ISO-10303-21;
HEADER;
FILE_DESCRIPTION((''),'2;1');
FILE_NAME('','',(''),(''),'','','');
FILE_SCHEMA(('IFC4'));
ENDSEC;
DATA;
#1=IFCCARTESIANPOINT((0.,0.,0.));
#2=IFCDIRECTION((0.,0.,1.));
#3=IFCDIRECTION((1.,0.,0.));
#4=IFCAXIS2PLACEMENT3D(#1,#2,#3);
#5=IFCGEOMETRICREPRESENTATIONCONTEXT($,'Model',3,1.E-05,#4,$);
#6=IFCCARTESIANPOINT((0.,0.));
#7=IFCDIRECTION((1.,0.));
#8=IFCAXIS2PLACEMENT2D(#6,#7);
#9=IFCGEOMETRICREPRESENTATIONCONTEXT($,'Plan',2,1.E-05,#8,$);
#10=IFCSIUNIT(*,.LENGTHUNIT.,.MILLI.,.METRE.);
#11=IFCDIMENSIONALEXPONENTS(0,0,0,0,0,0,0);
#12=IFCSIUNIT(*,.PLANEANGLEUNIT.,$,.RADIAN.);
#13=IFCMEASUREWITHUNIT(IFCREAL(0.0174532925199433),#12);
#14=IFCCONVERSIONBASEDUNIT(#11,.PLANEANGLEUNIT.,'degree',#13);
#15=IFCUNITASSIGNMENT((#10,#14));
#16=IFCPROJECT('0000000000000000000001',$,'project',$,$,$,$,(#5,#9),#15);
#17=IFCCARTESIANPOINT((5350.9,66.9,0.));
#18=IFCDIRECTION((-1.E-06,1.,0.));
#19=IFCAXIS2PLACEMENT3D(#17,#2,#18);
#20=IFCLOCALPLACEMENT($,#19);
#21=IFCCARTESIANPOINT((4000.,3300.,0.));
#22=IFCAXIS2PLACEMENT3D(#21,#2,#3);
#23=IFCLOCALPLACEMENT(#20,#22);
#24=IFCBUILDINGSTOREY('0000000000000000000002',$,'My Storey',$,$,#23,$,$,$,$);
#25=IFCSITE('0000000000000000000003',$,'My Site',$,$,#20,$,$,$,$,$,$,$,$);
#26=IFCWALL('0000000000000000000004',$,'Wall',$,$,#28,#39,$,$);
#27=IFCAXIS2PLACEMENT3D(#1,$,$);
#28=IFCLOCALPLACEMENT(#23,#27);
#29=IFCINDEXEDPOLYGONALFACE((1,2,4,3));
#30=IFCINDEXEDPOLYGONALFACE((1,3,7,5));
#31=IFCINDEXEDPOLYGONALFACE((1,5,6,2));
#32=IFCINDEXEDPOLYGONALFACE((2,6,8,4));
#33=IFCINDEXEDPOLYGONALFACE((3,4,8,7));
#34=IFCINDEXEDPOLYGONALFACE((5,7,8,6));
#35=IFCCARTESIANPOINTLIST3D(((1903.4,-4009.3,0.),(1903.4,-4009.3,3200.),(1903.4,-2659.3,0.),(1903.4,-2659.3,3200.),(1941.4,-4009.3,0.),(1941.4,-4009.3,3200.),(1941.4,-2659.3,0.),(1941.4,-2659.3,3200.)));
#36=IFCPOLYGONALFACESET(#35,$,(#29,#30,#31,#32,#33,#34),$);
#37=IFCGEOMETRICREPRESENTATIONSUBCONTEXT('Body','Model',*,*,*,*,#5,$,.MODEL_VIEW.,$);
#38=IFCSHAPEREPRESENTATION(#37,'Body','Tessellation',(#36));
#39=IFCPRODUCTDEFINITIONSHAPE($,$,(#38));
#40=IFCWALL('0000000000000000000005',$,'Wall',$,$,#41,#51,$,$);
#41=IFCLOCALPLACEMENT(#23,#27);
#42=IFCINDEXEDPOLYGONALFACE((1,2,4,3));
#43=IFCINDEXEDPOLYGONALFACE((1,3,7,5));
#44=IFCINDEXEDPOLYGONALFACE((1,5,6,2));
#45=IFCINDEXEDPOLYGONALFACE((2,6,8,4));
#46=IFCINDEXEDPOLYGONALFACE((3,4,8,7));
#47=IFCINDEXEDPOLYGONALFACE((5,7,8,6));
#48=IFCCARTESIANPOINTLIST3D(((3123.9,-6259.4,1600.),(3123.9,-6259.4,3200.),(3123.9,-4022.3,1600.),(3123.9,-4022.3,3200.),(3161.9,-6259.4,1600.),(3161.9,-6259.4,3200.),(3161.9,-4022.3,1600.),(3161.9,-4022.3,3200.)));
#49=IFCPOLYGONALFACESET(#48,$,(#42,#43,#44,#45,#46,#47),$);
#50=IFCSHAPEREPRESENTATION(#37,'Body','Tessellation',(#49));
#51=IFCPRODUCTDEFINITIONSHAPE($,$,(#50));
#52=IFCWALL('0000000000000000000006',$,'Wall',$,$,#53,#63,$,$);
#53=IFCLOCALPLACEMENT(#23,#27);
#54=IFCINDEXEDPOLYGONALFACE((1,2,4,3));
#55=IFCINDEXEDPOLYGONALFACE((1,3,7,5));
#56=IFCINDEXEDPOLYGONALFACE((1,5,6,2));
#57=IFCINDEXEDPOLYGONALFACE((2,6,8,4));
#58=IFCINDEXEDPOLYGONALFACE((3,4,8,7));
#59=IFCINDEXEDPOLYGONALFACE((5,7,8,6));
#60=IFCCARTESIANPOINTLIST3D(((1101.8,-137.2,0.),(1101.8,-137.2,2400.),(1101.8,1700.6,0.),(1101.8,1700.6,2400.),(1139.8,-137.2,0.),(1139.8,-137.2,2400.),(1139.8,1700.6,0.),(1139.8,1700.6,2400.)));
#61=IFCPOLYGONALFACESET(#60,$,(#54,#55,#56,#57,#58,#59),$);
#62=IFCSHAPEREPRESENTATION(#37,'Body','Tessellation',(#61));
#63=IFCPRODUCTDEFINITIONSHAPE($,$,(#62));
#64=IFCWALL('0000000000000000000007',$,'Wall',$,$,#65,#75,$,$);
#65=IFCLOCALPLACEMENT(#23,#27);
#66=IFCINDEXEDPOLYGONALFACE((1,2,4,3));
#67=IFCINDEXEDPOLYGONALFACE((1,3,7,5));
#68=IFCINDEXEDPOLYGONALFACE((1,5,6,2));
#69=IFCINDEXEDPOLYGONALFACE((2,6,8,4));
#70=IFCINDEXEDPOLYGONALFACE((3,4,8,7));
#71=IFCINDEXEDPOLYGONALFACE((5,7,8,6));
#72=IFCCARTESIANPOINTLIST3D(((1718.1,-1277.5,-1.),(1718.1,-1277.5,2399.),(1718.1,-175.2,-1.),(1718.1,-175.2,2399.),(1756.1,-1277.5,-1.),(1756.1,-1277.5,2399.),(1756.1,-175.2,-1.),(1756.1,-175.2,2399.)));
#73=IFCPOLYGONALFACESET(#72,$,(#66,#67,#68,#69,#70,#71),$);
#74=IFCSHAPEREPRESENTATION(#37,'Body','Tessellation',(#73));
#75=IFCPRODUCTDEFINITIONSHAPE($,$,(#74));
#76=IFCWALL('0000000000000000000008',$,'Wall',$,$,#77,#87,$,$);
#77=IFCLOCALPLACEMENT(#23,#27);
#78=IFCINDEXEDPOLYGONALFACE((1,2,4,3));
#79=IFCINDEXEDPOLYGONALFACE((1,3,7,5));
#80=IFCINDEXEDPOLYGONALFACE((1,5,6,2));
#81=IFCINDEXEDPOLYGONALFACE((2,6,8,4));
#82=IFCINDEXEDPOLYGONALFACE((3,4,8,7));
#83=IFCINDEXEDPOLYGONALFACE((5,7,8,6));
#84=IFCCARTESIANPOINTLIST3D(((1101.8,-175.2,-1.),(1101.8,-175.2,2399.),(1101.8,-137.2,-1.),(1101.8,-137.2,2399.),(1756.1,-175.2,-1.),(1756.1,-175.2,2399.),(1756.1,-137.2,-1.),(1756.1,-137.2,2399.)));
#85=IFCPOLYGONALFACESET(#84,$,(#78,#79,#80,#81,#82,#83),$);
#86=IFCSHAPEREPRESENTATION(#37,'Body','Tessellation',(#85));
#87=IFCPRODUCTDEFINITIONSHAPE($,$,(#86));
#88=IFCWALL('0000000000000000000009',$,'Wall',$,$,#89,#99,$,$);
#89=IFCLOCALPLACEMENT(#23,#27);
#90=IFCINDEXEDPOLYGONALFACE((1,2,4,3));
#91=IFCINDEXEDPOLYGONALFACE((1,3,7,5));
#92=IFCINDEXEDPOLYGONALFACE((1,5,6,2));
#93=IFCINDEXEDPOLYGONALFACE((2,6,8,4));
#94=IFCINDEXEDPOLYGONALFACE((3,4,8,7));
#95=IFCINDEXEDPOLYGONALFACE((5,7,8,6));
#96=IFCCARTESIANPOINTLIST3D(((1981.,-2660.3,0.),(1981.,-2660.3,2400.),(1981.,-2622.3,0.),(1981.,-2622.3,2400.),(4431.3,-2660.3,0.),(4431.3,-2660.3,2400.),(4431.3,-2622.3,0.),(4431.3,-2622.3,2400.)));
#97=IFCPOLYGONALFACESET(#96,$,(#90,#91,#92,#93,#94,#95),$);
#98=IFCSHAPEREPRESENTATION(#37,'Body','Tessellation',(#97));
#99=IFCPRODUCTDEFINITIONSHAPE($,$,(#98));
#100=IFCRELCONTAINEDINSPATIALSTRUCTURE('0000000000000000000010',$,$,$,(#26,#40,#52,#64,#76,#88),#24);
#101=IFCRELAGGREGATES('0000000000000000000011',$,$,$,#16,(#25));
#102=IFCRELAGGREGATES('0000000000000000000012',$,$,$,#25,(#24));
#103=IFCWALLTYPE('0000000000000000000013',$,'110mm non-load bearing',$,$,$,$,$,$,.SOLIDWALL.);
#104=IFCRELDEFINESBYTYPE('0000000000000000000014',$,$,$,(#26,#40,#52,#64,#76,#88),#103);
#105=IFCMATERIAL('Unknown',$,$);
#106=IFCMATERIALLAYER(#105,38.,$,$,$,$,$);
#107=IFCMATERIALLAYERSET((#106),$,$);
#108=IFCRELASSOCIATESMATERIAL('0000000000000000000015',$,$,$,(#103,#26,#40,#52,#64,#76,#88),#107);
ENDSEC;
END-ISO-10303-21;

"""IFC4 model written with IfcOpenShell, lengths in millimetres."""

from ifc_helpers import new_model, entity, si_unit, converted_unit, frame, origin_with_axes, origin_2d_with_axis, place, context, subcontext, project, spatial, indexed_curve, outline, extrude, material, layer, layer_set, layer_usage, type_object, element, save


model = new_model("IFC4")

# Units and contexts
model_context = context("Model", 3, precision=1e-05, world=origin_with_axes())
plan_context = context("Plan", 2, precision=1e-05, world=origin_2d_with_axis())
body_context = subcontext(model_context, "Body", "Model", "MODEL_VIEW")
ifc_project = project(units=[si_unit("LENGTHUNIT", "METRE", prefix="MILLI"), converted_unit("PLANEANGLEUNIT", "degree", entity("IfcReal", 0.0174532925199433), si_unit("PLANEANGLEUNIT", "RADIAN"), dimensions=[0, 0, 0, 0, 0, 0, 0])], contexts=[model_context, plan_context])

# Site, storey
site_placement = place(None, frame((5350.9, 66.9, 0.0), z_axis=(0.0, 0.0, 1.0), x_axis=(-0.000001, 1.0, 0.0)))
site = spatial("IfcSite", under=ifc_project, at=site_placement, Name="My Site")
storey_placement = place(site_placement, frame((4000.0, 3300.0, 0.0), z_axis=(0.0, 0.0, 1.0), x_axis=(1.0, 0.0, 0.0)))
storey = spatial("IfcBuildingStorey", under=site, at=storey_placement, Name="My Storey")

# Shared definitions
ifc_material = material(Name="Unknown")

# Walls
ifc_layer_1 = layer(ifc_material, 38.0)
ifc_layer_set_1 = layer_set([ifc_layer_1])
wall_type_1 = type_object("IfcWallType", Name="110mm non-load bearing", PredefinedType="SOLIDWALL", material=ifc_layer_set_1)
ifc_layer_usage_1 = layer_usage(ifc_layer_set_1, "AXIS2", "POSITIVE", 0.0)
wall_1_placement = place(storey_placement, frame((1903.4, -2659.3, 0.0), z_axis=(0.0, 0.0, 1.0), x_axis=(-0.000001, -1.0, 0.0)))
element("IfcWall", 1, at=wall_1_placement, inside=storey, type_object=wall_type_1, material=ifc_layer_usage_1, Name="Wall", context=body_context, shape_type="SweptSolid", body=[
    extrude(outline(indexed_curve([(0.0, 0.0), (0.0, 38.0), (1350.0, 38.0), (1350.0, 0.0), (0.0, 0.0)], self_intersect=False)), origin_with_axes(), (0.0, 0.0, 1.0), 3200.0),
])
ifc_layer_usage_2 = layer_usage(ifc_layer_set_1, "AXIS2", "POSITIVE", 0.0)
wall_2_placement = place(storey_placement, frame((3161.9, -6259.4, 1600.0), z_axis=(0.0, 0.0, 1.0), x_axis=(0.000001, 1.0, 0.0)))
element("IfcWall", 2, at=wall_2_placement, inside=storey, type_object=wall_type_1, material=ifc_layer_usage_2, Name="Wall", context=body_context, shape_type="SweptSolid", body=[
    extrude(outline(indexed_curve([(0.0, 0.0), (0.0, 38.0), (2237.1, 38.0), (2237.1, 0.0), (0.0, 0.0)], self_intersect=False)), origin_with_axes(), (0.0, 0.0, 1.0), 1600.0),
])
ifc_layer_usage_3 = layer_usage(ifc_layer_set_1, "AXIS2", "POSITIVE", 0.0)
wall_3_placement = place(storey_placement, frame((1101.8, 1700.6, 0.0), z_axis=(0.0, 0.0, 1.0), x_axis=(-0.000001, -1.0, 0.0)))
element("IfcWall", 3, at=wall_3_placement, inside=storey, type_object=wall_type_1, material=ifc_layer_usage_3, Name="Wall", context=body_context, shape_type="SweptSolid", body=[
    extrude(outline(indexed_curve([(0.0, 0.0), (0.0, 38.0), (1837.8, 38.0), (1837.8, 0.0), (0.0, 0.0)], self_intersect=False)), origin_with_axes(), (0.0, 0.0, 1.0), 2400.0),
])
ifc_layer_usage_4 = layer_usage(ifc_layer_set_1, "AXIS2", "POSITIVE", 0.0)
wall_4_placement = place(storey_placement, frame((1718.1, -175.2, -1.0), z_axis=(0.0, 0.0, 1.0), x_axis=(-0.000001, -1.0, 0.0)))
element("IfcWall", 4, at=wall_4_placement, inside=storey, type_object=wall_type_1, material=ifc_layer_usage_4, Name="Wall", context=body_context, shape_type="SweptSolid", body=[
    extrude(outline(indexed_curve([(0.0, 0.0), (0.0, 38.0), (1102.3, 38.0), (1102.3, 0.0), (0.0, 0.0)], self_intersect=False)), origin_with_axes(), (0.0, 0.0, 1.0), 2400.0),
])
ifc_layer_usage_5 = layer_usage(ifc_layer_set_1, "AXIS2", "POSITIVE", 0.0)
wall_5_placement = place(storey_placement, frame((1101.8, -175.2, -1.0), z_axis=(0.0, 0.0, 1.0), x_axis=(1.0, -0.000001, 0.0)))
element("IfcWall", 5, at=wall_5_placement, inside=storey, type_object=wall_type_1, material=ifc_layer_usage_5, Name="Wall", context=body_context, shape_type="SweptSolid", body=[
    extrude(outline(indexed_curve([(0.0, 0.0), (0.0, 38.0), (654.3, 38.0), (654.3, 0.0), (0.0, 0.0)], self_intersect=False)), origin_with_axes(), (0.0, 0.0, 1.0), 2400.0),
])
ifc_layer_usage_6 = layer_usage(ifc_layer_set_1, "AXIS2", "POSITIVE", 0.0)
wall_6_placement = place(storey_placement, frame((1981.0, -2660.3, 0.0), z_axis=(0.0, 0.0, 1.0), x_axis=(1.0, 0.0, 0.0)))
element("IfcWall", 6, at=wall_6_placement, inside=storey, type_object=wall_type_1, material=ifc_layer_usage_6, Name="Wall", context=body_context, shape_type="SweptSolid", body=[
    extrude(outline(indexed_curve([(0.0, 0.0), (0.0, 38.0), (2450.3, 38.0), (2450.3, 0.0), (0.0, 0.0)], self_intersect=False)), origin_with_axes(), (0.0, 0.0, 1.0), 2400.0),
])

save(model, "model.ifc")
